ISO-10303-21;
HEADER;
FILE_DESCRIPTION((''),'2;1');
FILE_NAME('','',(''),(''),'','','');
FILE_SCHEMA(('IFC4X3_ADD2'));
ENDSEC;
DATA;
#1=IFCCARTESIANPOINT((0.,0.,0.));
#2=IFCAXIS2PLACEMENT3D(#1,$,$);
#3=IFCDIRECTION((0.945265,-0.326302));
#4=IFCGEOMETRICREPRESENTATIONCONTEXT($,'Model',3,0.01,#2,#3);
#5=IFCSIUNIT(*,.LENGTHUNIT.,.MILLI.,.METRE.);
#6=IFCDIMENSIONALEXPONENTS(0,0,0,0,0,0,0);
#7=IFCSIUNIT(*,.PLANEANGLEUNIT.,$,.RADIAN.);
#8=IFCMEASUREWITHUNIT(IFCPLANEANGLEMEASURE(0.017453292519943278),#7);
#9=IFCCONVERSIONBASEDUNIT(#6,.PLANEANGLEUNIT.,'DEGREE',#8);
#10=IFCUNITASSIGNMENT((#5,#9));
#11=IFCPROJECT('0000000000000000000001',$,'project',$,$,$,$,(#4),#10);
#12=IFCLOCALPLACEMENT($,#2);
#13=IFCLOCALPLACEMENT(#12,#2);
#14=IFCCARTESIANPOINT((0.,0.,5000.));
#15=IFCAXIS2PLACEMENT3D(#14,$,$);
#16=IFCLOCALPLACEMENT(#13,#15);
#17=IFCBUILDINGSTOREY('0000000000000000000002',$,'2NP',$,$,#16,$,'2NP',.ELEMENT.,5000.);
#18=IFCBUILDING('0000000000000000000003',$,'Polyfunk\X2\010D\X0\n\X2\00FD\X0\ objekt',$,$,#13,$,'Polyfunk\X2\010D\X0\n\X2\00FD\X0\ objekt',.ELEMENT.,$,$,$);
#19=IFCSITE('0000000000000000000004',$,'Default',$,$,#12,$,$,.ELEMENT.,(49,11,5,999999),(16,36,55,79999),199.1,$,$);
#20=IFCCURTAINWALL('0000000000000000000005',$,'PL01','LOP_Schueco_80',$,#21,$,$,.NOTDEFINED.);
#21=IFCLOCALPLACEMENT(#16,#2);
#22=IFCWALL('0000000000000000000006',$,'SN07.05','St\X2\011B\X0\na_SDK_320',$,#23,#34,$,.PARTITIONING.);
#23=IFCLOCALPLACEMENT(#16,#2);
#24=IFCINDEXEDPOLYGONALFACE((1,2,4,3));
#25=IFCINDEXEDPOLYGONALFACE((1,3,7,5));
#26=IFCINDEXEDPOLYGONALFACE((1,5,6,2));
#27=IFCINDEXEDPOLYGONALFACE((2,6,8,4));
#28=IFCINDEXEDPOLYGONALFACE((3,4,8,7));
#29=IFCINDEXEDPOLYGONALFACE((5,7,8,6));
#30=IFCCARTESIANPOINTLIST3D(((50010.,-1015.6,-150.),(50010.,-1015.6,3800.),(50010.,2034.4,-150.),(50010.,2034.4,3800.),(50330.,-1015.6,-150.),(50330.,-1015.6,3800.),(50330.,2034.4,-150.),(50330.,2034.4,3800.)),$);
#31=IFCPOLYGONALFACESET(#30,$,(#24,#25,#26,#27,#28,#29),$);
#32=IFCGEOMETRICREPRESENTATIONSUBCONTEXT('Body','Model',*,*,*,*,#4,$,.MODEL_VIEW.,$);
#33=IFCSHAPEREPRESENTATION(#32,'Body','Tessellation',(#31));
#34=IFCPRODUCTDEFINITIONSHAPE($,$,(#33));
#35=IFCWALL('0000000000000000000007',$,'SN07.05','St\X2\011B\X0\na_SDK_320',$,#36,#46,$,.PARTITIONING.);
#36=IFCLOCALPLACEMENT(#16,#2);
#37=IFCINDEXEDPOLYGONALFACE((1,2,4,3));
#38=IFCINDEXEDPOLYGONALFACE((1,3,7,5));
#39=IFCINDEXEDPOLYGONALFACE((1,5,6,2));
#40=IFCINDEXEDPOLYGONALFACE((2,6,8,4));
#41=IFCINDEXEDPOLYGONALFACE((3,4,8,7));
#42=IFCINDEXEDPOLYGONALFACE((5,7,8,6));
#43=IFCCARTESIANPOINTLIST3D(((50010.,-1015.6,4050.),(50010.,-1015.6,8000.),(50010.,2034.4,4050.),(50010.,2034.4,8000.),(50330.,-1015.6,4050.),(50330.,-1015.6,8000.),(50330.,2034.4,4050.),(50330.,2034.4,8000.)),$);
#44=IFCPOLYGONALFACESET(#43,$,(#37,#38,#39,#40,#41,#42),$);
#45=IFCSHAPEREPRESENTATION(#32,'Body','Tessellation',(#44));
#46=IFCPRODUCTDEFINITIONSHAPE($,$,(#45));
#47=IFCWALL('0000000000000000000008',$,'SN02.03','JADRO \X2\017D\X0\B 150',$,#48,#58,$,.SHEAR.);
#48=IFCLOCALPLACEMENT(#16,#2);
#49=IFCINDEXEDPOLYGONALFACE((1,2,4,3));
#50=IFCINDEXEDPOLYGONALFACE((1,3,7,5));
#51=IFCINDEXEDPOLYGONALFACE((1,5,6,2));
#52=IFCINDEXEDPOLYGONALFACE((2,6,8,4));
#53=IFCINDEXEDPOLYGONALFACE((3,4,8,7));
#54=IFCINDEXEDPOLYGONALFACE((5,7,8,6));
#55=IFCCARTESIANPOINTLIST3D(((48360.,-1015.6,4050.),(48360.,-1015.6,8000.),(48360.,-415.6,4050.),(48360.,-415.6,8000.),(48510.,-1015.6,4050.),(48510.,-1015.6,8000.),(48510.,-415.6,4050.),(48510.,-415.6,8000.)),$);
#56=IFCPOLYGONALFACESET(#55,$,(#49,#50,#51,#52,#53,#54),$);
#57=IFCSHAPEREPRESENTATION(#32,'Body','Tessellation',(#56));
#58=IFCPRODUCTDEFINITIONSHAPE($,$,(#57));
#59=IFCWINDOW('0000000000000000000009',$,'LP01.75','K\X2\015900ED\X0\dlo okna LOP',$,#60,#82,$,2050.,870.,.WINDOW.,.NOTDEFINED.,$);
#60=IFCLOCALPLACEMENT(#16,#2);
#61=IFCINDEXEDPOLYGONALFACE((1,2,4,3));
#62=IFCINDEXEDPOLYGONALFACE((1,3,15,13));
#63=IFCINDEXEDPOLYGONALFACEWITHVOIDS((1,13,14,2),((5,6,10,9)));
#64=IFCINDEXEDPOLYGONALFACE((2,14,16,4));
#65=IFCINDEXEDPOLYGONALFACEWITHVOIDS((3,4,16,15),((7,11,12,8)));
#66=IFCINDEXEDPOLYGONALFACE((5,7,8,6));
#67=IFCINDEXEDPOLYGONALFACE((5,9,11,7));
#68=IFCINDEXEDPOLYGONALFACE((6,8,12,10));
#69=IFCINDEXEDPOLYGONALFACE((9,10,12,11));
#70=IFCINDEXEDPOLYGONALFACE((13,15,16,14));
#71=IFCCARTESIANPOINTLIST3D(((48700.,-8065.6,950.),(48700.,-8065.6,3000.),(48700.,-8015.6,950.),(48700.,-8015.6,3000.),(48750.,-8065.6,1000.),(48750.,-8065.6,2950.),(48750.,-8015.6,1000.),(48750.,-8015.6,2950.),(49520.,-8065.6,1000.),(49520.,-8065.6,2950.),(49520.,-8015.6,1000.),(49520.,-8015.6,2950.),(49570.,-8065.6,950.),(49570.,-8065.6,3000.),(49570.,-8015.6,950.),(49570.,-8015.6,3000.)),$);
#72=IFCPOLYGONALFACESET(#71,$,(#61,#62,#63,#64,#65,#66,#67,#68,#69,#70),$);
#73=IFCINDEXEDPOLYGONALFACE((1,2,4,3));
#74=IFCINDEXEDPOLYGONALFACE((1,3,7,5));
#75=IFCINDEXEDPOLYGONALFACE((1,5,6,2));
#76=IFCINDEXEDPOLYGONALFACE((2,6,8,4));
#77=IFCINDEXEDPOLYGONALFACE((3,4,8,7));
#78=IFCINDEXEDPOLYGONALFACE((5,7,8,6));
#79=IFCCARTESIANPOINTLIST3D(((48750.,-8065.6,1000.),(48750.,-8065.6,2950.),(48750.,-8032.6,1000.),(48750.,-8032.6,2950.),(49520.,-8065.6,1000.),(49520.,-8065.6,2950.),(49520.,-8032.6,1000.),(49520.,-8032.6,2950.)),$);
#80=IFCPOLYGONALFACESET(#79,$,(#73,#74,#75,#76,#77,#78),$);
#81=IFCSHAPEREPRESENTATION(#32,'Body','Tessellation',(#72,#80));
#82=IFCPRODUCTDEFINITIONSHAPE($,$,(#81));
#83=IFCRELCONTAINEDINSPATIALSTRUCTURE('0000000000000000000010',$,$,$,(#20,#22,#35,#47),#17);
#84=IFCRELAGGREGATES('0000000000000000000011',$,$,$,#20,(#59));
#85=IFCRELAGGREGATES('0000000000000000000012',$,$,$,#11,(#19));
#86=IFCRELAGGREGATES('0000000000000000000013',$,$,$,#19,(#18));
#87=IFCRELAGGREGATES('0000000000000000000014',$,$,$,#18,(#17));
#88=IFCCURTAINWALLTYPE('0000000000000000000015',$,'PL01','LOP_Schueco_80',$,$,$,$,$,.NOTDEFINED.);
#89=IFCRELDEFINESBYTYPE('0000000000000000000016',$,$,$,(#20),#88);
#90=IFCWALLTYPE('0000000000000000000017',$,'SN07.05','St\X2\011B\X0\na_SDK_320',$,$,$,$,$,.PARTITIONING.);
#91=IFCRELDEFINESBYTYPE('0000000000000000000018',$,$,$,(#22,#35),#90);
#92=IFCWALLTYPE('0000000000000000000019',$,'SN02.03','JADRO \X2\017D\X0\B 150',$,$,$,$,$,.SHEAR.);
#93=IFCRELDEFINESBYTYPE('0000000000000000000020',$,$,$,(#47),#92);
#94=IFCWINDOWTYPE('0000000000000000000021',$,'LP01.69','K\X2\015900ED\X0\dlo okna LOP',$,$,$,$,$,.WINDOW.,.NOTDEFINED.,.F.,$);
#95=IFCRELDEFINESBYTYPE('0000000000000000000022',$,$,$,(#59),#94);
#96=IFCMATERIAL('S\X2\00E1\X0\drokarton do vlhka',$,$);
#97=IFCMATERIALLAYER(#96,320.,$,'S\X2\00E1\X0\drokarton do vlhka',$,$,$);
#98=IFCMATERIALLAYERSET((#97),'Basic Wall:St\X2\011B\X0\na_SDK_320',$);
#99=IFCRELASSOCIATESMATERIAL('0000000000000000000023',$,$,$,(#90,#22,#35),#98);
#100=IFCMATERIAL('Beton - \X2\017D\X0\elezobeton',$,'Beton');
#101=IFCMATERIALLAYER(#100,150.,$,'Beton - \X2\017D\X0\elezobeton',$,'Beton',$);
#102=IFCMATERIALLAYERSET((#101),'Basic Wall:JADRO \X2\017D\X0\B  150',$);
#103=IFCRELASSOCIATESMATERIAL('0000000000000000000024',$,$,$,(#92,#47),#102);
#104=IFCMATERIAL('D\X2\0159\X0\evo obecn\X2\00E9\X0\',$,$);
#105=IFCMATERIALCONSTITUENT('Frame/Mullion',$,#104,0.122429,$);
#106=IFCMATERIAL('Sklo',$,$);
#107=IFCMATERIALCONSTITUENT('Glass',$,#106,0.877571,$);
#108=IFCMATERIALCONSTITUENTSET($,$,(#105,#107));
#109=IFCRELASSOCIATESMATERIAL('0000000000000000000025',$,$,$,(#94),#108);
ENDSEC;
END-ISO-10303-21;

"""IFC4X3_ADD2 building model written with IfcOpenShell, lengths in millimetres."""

from ifc_helpers import new_model, entity, si_unit, converted_unit, direction, frame, frame_2d, origin, place, context, subcontext, project, spatial, polyline, rectangle, outline, extrude, clip, bounded_halfspace, source, transform, mapped, material, layer, layer_set, constituent, constituent_set, type_object, type_shapes, element, aggregate, save


model = new_model("IFC4X3_ADD2")

# Units and contexts
model_context = context("Model", 3, precision=0.01, world=origin(), true_north=direction((0.945265, -0.326302)))
body_context = subcontext(model_context, "Body", "Model", "MODEL_VIEW")
ifc_project = project(units=[si_unit("LENGTHUNIT", "METRE", prefix="MILLI"), converted_unit("PLANEANGLEUNIT", "DEGREE", entity("IfcPlaneAngleMeasure", 0.017453292519943278), si_unit("PLANEANGLEUNIT", "RADIAN"), dimensions=[0, 0, 0, 0, 0, 0, 0])], contexts=[model_context])

# Site, building, storey
site_placement = place(None, origin())
site = spatial("IfcSite", under=ifc_project, at=site_placement, Name="Default", CompositionType="ELEMENT", RefLatitude=(49, 11, 5, 999999), RefLongitude=(16, 36, 55, 79999), RefElevation=199.1)
building_placement = place(site_placement, origin())
building = spatial("IfcBuilding", under=site, at=building_placement, Name="Polyfunkčný objekt", LongName="Polyfunkčný objekt", CompositionType="ELEMENT")
storey_placement = place(building_placement, frame((0.0, 0.0, 5000.0)))
storey = spatial("IfcBuildingStorey", under=building, at=storey_placement, Name="2NP", LongName="2NP", CompositionType="ELEMENT", Elevation=5000.0)

# Curtain wall
curtain_wall_type = type_object("IfcCurtainWallType", Name="PL01", Description="LOP_Schueco_80", PredefinedType="NOTDEFINED")
curtain_wall_placement = place(storey_placement, frame((0.0, 0.0, -5000.0)))
curtain_wall = element("IfcCurtainWall", 1, at=curtain_wall_placement, inside=storey, type_object=curtain_wall_type, Name="PL01", Description="LOP_Schueco_80", PredefinedType="NOTDEFINED")
ifc_material_1 = material(Name="Sklo")

# Walls
ifc_material_2 = material(Name="Sádrokarton do vlhka")
ifc_layer_1 = layer(ifc_material_2, 320.0, Name="Sádrokarton do vlhka")
ifc_layer_set_1 = layer_set([ifc_layer_1], Name="Basic Wall:Stěna_SDK_320")
wall_type_1 = type_object("IfcWallType", Name="SN07.05", Description="Stěna_SDK_320", PredefinedType="PARTITIONING", material=ifc_layer_set_1)
wall_1_placement = place(storey_placement, frame((50170.0, 2034.4, -150.0), z_axis=(0.0, 0.0, 1.0), x_axis=(0.0, -1.0, 0.0)))
element("IfcWall", 2, at=wall_1_placement, inside=storey, type_object=wall_type_1, material=ifc_layer_set_1, Name="SN07.05", Description="Stěna_SDK_320", PredefinedType="PARTITIONING", context=body_context, shape_type="Clipping", body=[
    clip(clip(extrude(rectangle(XDim=3050.0, YDim=320.0, at=frame_2d((1525.0, 0.0), x_axis=(-1.0, 0.0))), origin(), (0.0, 0.0, 1.0), 3950.0), bounded_halfspace(frame((3050.0, -160.0, 0.0), z_axis=(0.0, 0.0, 1.0), x_axis=(0.0, -1.0, 0.0)), True, frame((3050.0, -160.0, 0.0)), polyline([(0.0, 0.0), (0.0, 320.0), (-1600.0, 320.0), (-1750.0, 320.0), (-2900.0, 320.0), (-3050.0, 320.0), (-3050.0, 0.0), (0.0, 0.0)]))), bounded_halfspace(frame((0.0, -160.0, 3950.0), z_axis=(0.0, 0.0, -1.0), x_axis=(0.0, 1.0, 0.0)), True, frame((0.0, -160.0, 3950.0)), polyline([(0.0, 0.0), (3050.0, 0.0), (3050.0, 320.0), (1450.0, 320.0), (1300.0, 320.0), (150.0, 320.0), (0.0, 320.0), (0.0, 0.0)]))),
])
wall_2_placement = place(storey_placement, frame((50170.0, 2034.4, 4050.0), z_axis=(0.0, 0.0, 1.0), x_axis=(0.0, -1.0, 0.0)))
element("IfcWall", 3, at=wall_2_placement, inside=storey, type_object=wall_type_1, material=ifc_layer_set_1, Name="SN07.05", Description="Stěna_SDK_320", PredefinedType="PARTITIONING", context=body_context, shape_type="Clipping", body=[
    clip(clip(extrude(rectangle(XDim=3050.0, YDim=320.0, at=frame_2d((1525.0, 0.0), x_axis=(-1.0, 0.0))), origin(), (0.0, 0.0, 1.0), 3950.0), bounded_halfspace(frame((3050.0, -160.0, 0.0), z_axis=(0.0, 0.0, 1.0), x_axis=(0.0, -1.0, 0.0)), True, frame((3050.0, -160.0, 0.0)), polyline([(0.0, 0.0), (0.0, 320.0), (-1600.0, 320.0), (-1750.0, 320.0), (-2900.0, 320.0), (-3050.0, 320.0), (-3050.0, 0.0), (0.0, 0.0)]))), bounded_halfspace(frame((0.0, -160.0, 3950.0), z_axis=(0.0, 0.0, -1.0), x_axis=(0.0, 1.0, 0.0)), True, frame((0.0, -160.0, 3950.0)), polyline([(0.0, 0.0), (3050.0, 0.0), (3050.0, 320.0), (1450.0, 320.0), (1300.0, 320.0), (150.0, 320.0), (0.0, 320.0), (0.0, 0.0)]))),
])
ifc_material_3 = material(Name="Beton - Železobeton", Category="Beton")
ifc_layer_2 = layer(ifc_material_3, 150.0, Name="Beton - Železobeton", Category="Beton")
ifc_layer_set_2 = layer_set([ifc_layer_2], Name="Basic Wall:JADRO ŽB  150")
wall_type_2 = type_object("IfcWallType", Name="SN02.03", Description="JADRO ŽB 150", PredefinedType="SHEAR", material=ifc_layer_set_2)
wall_3_placement = place(storey_placement, frame((48435.0, -1015.6, 4050.0), z_axis=(0.0, 0.0, 1.0), x_axis=(0.0, 1.0, 0.0)))
element("IfcWall", 4, at=wall_3_placement, inside=storey, type_object=wall_type_2, material=ifc_layer_set_2, Name="SN02.03", Description="JADRO ŽB 150", PredefinedType="SHEAR", context=body_context, shape_type="SweptSolid", body=[
    extrude(rectangle(XDim=600.0, YDim=150.0, at=frame_2d((300.0, 0.0), x_axis=(-1.0, 0.0))), origin(), (0.0, 0.0, 1.0), 3950.0),
])

# Window
ifc_material_4 = material(Name="Dřevo obecné")
ifc_constituent_1 = constituent(ifc_material_4, Name="Frame/Mullion", fraction=0.122429)
ifc_constituent_2 = constituent(ifc_material_1, Name="Glass", fraction=0.877571)
ifc_constituent_set = constituent_set(constituents=[ifc_constituent_1, ifc_constituent_2])
window_type = type_object("IfcWindowType", Name="LP01.69", Description="Křídlo okna LOP", ParameterTakesPrecedence=False, PartitioningType="NOTDEFINED", PredefinedType="WINDOW", material=ifc_constituent_set)
shared_shape_1 = source(origin(), body_context, "Body", "SweptSolid", [
    extrude(outline(polyline([(-1025.0, -435.0), (1025.0, -435.0), (1025.0, 435.0), (-1025.0, 435.0), (-1025.0, -435.0)]), holes=[polyline([(-975.0, -385.0), (-975.0, 385.0), (975.0, 385.0), (975.0, -385.0), (-975.0, -385.0)])]), frame((0.0, 50.0, 1025.0), z_axis=(0.0, -1.0, 0.0), x_axis=(0.0, 0.0, -1.0)), (0.0, 0.0, 1.0), 50.0),
    extrude(rectangle(XDim=770.0, YDim=33.0, at=frame_2d((0.0, 0.0), x_axis=(1.0, 0.0))), frame((0.0, 33.5, 50.0), z_axis=(0.0, 0.0, 1.0), x_axis=(-1.0, 0.0, 0.0)), (0.0, 0.0, 1.0), 1950.0),
])
type_shapes(window_type, [shared_shape_1])
window_placement = place(curtain_wall_placement, frame((49135.0, -8015.6, 5950.0), z_axis=(0.0, 0.0, 1.0), x_axis=(-1.0, 0.0, 0.0)))
window = element("IfcWindow", 5, at=window_placement, type_object=window_type, Name="LP01.75", Description="Křídlo okna LOP", OverallHeight=2050.0, OverallWidth=870.0, PartitioningType="NOTDEFINED", PredefinedType="WINDOW", context=body_context, shape_type="MappedRepresentation", body=[
    mapped(shared_shape_1, transform((0.0, 0.0, 0.0), scale=1.0)),
])
aggregate(curtain_wall, [window])

save(model, "model.ifc")
